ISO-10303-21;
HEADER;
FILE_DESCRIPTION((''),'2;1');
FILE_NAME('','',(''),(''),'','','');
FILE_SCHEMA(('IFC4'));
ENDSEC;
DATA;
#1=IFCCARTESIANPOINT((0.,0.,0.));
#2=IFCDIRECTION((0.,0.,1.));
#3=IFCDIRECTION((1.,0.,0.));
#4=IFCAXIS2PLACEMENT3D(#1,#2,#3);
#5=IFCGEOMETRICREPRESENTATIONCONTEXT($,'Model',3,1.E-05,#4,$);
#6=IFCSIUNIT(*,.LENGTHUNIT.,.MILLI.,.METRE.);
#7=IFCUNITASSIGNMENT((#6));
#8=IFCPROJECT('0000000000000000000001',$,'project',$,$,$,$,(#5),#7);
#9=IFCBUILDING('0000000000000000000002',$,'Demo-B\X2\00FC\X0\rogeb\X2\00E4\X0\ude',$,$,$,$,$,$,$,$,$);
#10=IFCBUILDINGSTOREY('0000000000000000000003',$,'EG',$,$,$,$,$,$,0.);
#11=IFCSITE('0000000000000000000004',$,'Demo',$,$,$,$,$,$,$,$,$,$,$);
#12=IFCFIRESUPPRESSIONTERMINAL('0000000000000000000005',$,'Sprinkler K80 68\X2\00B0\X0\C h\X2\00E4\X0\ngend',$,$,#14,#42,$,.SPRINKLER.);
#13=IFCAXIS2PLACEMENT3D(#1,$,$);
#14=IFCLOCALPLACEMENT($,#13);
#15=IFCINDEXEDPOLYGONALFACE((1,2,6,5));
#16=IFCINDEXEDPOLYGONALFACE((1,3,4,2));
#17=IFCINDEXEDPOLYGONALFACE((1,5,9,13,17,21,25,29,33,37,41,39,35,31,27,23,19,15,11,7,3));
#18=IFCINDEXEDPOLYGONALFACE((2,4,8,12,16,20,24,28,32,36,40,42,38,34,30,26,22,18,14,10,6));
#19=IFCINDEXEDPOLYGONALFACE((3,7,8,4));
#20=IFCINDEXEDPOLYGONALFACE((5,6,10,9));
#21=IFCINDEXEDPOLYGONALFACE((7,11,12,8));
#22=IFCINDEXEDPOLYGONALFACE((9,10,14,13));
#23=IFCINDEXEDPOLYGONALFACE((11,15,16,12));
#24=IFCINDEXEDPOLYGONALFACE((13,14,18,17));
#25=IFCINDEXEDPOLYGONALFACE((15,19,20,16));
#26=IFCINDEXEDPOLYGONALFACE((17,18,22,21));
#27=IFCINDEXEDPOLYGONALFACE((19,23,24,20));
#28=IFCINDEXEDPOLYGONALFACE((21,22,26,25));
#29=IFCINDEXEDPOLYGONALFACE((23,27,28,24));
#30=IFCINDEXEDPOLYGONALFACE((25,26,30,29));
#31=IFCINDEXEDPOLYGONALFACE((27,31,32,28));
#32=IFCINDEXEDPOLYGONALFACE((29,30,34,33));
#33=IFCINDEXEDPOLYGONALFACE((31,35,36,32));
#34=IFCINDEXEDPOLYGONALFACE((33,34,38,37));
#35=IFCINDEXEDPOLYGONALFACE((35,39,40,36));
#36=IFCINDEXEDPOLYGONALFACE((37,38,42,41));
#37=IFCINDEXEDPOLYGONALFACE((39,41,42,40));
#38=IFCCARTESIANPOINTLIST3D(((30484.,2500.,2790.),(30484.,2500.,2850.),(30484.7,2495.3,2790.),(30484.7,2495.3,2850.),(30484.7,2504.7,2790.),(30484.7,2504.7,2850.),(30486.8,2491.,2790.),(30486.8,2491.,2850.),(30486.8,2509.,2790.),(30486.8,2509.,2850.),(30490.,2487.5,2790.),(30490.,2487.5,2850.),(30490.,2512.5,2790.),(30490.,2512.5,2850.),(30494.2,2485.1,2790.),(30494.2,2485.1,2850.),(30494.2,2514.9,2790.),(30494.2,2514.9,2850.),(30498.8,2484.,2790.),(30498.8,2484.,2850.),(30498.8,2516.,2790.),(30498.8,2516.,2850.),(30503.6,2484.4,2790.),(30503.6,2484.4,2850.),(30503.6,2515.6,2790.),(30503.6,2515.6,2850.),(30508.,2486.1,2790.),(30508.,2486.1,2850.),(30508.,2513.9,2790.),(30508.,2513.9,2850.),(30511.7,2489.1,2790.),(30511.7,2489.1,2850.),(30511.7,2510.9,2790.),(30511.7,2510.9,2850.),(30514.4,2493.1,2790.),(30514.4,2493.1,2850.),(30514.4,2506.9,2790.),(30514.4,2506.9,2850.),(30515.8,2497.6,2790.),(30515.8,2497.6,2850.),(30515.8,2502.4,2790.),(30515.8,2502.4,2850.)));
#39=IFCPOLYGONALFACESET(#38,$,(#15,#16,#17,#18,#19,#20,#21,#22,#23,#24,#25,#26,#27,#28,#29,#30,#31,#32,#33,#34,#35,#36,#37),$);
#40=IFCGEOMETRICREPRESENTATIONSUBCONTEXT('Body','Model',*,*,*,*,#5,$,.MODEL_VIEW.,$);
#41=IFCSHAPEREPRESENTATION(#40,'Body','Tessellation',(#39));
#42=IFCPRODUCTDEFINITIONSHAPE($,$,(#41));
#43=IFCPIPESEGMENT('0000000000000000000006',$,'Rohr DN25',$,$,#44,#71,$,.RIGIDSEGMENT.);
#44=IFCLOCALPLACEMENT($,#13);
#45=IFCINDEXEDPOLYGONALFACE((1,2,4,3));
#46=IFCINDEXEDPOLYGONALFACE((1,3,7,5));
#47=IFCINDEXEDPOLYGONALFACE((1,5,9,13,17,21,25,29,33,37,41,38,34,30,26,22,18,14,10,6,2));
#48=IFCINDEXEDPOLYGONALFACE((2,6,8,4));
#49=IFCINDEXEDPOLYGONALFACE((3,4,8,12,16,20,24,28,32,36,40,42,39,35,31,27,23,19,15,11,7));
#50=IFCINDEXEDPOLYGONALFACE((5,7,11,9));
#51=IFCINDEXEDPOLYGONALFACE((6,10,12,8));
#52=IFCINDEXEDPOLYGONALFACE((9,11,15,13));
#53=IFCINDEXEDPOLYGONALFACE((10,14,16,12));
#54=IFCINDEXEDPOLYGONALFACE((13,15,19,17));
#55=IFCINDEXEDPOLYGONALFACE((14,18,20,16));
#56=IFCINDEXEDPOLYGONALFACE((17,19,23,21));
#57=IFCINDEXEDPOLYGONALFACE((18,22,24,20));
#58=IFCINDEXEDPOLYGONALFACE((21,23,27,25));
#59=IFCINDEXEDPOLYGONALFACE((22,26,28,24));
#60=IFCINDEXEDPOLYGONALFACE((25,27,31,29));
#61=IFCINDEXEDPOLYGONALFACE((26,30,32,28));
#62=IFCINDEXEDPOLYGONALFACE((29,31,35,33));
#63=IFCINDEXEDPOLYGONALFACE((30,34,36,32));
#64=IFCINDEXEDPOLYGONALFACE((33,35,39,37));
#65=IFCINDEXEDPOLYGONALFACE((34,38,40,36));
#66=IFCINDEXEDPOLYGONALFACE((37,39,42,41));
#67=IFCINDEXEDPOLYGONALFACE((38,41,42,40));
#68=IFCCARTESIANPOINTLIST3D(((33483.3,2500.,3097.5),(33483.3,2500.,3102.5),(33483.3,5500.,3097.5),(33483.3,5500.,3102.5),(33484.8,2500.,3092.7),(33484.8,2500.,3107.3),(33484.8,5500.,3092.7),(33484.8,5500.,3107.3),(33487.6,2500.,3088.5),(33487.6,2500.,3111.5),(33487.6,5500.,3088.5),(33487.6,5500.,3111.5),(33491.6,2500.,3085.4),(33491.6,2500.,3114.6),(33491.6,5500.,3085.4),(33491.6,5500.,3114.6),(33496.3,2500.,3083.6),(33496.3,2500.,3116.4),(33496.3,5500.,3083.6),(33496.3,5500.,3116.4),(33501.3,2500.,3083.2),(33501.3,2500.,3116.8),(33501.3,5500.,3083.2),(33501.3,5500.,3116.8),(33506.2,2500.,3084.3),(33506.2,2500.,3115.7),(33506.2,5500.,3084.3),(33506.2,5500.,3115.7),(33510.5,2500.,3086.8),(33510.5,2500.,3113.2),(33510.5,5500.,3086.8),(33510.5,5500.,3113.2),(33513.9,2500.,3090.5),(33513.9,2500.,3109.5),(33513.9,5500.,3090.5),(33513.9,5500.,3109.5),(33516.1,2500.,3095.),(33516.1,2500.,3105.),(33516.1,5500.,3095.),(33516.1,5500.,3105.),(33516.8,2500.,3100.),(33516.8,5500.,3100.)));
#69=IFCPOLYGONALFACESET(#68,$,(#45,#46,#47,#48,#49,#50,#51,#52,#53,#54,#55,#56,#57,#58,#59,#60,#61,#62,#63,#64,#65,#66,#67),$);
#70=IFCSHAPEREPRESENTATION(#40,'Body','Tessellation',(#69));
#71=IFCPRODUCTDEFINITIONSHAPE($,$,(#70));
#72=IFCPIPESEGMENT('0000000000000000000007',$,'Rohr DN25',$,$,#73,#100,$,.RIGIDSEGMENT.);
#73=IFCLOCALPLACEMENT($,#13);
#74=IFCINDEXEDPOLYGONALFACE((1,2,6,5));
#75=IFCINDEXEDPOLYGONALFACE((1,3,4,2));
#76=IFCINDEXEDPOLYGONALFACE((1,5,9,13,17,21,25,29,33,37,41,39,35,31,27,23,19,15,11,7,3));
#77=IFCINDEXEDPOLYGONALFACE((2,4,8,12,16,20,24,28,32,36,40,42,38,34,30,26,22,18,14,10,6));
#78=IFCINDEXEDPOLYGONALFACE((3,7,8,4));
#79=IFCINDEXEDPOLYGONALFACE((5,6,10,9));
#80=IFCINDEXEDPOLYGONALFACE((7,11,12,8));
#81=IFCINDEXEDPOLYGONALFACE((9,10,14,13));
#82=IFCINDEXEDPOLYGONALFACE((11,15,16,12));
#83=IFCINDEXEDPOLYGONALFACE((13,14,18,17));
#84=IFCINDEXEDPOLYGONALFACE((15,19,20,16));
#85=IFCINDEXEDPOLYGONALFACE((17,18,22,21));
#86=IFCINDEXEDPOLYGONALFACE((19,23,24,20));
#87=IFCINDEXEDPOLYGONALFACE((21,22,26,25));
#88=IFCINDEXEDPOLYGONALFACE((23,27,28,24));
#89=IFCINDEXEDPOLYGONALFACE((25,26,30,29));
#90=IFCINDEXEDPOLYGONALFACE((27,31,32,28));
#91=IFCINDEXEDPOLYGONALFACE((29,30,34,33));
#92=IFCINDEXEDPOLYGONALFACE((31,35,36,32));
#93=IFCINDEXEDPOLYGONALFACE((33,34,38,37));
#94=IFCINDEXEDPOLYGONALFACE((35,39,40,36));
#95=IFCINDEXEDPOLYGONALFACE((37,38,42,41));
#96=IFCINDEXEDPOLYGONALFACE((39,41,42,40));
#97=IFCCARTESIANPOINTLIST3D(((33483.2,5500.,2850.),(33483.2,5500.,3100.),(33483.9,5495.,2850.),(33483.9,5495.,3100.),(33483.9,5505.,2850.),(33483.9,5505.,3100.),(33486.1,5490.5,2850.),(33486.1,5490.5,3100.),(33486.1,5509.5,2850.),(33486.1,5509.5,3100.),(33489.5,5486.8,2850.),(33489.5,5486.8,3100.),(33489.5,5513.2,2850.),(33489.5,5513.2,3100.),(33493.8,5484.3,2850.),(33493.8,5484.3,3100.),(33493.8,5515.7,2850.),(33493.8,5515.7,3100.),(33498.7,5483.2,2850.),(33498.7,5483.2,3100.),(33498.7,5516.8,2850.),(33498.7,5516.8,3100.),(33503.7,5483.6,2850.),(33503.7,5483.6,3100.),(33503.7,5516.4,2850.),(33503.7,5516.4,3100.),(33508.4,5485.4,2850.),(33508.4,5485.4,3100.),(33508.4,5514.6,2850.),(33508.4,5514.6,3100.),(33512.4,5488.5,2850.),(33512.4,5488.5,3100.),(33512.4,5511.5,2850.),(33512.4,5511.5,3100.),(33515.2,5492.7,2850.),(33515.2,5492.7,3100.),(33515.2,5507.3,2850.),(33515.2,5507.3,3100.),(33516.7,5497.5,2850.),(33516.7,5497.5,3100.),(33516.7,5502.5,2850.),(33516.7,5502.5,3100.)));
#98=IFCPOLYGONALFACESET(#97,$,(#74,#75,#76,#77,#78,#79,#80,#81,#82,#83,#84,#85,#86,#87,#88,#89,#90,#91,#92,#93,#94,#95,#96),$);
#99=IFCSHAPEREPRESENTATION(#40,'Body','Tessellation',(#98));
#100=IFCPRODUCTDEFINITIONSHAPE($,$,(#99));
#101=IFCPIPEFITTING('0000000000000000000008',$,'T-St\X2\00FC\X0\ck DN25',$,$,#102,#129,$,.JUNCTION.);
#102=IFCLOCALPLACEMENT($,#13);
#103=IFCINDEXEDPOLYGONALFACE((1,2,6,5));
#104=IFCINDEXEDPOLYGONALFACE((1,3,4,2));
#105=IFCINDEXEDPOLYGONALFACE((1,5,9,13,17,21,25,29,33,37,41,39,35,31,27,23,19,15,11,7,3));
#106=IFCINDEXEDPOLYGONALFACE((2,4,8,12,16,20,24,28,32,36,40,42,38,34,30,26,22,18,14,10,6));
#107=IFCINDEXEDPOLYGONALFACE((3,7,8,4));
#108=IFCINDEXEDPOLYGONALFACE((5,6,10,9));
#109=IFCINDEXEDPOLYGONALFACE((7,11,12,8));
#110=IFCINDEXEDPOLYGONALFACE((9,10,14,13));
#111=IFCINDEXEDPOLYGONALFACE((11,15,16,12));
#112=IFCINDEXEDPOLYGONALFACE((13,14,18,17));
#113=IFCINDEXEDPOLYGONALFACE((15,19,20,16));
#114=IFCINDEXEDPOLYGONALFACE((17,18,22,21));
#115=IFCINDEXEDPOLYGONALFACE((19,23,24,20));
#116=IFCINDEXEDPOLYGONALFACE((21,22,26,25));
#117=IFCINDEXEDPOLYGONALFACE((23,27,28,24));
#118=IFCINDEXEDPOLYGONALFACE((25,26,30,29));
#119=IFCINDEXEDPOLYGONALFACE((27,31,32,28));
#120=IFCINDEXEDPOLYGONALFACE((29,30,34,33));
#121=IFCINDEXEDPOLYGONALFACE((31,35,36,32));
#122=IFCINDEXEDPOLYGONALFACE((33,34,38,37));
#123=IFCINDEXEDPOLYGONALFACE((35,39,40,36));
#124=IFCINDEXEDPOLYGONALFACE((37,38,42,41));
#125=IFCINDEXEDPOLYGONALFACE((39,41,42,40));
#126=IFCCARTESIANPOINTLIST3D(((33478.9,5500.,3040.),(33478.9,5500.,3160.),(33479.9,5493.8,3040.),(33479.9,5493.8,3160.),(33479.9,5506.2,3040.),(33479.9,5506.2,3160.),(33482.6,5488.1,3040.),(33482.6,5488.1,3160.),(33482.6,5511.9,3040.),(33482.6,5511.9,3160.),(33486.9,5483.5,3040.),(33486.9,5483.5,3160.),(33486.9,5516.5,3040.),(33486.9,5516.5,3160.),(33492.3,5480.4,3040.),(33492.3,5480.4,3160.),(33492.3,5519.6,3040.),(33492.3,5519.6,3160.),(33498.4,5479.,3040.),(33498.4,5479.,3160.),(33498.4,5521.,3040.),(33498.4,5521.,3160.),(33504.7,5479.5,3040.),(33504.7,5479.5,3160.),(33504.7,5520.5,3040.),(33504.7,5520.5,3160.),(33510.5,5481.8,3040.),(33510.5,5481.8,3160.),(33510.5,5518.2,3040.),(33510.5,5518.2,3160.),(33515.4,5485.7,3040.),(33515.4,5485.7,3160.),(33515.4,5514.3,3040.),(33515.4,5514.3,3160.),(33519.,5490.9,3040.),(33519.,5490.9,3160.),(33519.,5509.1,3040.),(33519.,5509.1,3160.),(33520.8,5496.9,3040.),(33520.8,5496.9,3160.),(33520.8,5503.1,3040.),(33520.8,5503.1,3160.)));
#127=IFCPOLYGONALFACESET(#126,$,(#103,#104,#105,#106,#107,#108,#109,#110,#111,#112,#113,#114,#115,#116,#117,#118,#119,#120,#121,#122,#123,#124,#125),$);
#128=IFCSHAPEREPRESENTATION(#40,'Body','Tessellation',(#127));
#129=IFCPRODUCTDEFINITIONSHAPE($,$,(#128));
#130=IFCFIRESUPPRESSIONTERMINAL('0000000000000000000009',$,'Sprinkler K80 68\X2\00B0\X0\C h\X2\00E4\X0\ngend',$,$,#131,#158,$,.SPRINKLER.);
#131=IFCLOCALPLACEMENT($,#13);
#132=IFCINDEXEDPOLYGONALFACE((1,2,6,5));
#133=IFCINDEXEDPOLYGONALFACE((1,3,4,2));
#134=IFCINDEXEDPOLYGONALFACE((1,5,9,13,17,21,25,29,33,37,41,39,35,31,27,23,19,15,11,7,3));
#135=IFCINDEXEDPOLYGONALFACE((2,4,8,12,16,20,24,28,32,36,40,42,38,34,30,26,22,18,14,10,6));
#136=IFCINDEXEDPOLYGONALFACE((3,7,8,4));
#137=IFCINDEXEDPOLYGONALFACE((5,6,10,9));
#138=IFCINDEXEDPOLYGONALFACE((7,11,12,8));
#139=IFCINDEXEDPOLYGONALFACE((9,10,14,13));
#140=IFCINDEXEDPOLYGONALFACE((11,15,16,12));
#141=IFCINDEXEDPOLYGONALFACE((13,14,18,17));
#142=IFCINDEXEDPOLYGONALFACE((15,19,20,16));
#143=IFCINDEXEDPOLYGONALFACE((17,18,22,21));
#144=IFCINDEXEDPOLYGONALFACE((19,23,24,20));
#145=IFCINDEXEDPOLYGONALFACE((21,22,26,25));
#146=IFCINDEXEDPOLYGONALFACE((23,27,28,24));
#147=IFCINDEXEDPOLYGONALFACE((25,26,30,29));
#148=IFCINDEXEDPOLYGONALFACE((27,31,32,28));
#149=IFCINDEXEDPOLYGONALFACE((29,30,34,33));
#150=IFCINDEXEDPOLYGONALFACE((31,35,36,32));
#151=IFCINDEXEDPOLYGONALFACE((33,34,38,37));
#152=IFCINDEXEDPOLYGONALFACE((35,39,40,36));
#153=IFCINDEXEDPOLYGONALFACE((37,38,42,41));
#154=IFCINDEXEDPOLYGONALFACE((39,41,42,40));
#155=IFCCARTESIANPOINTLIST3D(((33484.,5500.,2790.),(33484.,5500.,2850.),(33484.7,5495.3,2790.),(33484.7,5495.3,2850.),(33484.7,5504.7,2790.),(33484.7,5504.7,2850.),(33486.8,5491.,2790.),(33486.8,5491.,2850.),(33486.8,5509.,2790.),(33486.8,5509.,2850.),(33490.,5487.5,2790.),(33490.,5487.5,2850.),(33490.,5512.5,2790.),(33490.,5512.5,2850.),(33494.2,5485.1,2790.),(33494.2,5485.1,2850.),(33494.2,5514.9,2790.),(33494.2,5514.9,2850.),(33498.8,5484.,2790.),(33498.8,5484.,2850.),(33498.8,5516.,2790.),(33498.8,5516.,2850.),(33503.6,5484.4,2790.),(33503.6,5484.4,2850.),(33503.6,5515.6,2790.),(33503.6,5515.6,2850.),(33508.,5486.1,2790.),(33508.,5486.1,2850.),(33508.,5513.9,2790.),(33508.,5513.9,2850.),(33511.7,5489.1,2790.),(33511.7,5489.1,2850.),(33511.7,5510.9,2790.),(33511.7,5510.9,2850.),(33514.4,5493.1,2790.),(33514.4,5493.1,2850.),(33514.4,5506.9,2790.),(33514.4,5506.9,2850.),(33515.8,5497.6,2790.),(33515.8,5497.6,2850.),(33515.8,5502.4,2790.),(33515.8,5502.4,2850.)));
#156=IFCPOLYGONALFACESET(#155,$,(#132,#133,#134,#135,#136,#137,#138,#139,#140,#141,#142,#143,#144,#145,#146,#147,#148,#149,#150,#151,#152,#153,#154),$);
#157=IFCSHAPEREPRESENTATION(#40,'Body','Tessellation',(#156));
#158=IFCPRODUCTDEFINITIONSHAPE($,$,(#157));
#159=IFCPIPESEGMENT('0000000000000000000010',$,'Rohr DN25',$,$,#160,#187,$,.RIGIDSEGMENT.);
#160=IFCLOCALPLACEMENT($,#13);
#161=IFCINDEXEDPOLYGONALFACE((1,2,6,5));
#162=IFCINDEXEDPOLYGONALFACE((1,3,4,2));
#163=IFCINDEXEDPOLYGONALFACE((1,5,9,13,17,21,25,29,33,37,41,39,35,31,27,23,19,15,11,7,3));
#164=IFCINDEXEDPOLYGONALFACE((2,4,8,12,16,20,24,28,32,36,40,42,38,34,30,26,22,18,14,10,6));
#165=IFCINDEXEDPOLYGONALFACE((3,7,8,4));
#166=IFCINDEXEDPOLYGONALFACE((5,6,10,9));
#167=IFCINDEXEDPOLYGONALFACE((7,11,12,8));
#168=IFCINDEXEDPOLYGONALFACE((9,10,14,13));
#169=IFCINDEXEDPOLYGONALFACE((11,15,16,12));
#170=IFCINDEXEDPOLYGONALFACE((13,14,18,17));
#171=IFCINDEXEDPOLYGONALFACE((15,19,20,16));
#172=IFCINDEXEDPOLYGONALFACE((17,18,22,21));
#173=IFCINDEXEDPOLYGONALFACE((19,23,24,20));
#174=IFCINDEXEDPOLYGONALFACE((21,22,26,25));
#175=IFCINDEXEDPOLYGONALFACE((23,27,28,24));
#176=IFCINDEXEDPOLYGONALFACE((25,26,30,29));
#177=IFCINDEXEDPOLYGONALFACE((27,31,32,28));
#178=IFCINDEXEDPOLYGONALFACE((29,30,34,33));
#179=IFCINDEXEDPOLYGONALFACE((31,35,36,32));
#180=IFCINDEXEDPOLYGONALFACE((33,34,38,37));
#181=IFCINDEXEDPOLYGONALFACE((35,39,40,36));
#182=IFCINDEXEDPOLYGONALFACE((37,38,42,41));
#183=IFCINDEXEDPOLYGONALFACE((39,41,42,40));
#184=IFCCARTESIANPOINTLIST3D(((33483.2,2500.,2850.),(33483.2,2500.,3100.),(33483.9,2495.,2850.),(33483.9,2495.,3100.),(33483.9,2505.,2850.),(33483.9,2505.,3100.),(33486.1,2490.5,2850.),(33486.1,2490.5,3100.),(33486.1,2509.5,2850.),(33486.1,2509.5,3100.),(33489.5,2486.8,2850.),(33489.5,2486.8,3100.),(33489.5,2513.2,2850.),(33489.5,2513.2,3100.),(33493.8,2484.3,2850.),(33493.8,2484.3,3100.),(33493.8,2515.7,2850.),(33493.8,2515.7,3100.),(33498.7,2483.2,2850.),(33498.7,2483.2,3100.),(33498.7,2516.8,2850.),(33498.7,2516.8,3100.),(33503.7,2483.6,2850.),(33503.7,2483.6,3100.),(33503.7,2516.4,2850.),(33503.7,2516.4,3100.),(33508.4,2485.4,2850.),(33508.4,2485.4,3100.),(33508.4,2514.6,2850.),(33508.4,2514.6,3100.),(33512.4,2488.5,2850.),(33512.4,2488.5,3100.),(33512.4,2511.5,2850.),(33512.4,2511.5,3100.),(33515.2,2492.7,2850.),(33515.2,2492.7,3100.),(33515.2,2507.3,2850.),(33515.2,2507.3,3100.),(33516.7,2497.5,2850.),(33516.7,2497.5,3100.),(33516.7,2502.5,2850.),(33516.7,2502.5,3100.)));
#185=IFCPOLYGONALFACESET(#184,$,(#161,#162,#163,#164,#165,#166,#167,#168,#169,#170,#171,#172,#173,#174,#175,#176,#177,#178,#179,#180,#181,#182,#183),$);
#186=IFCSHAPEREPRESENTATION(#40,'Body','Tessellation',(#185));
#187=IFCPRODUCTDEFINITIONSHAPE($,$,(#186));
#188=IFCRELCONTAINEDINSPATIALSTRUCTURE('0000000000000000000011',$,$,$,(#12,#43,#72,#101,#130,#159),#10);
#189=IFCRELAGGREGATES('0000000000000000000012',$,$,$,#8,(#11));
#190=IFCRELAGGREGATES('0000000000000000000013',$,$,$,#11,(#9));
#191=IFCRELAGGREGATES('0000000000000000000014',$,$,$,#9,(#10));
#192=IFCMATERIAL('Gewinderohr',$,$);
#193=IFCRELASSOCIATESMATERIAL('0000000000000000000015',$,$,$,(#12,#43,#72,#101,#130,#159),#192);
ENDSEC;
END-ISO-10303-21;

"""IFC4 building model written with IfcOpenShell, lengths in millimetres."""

from ifc_helpers import new_model, si_unit, frame, origin_with_axes, place, context, subcontext, project, spatial, circle, extrude, material, element, save


model = new_model("IFC4")

# Units and contexts
model_context = context("Model", 3, precision=1e-05, world=origin_with_axes())
body_context = subcontext(model_context, "Body", "Model", "MODEL_VIEW")
ifc_project = project(units=[si_unit("LENGTHUNIT", "METRE", prefix="MILLI")], contexts=[model_context])

# Site, building, storey
site = spatial("IfcSite", under=ifc_project, Name="Demo")
building = spatial("IfcBuilding", under=site, Name="Demo-Bürogebäude")
storey = spatial("IfcBuildingStorey", under=building, Name="EG", Elevation=0.0)

# Shared definitions
ifc_material_1 = material(Name="Gewinderohr")

# Fire suppression terminal
fire_suppression_terminal_1_placement = place(None, frame((30500.0, 2500.0, 2850.0), z_axis=(0.0, 0.0, -1.0), x_axis=(-1.0, 0.0, 0.0)))
element("IfcFireSuppressionTerminal", 1, at=fire_suppression_terminal_1_placement, inside=storey, material=ifc_material_1, Name="Sprinkler K80 68°C hängend", PredefinedType="SPRINKLER", context=body_context, shape_type="SweptSolid", body=[
    extrude(circle(Radius=16.0), origin_with_axes(), (0.0, 0.0, 1.0), 60.0),
])

# Pipe segments
pipe_segment_1_placement = place(None, frame((33500.0, 5500.0, 3100.0), z_axis=(0.0, -1.0, 0.0), x_axis=(1.0, 0.0, 0.0)))
element("IfcPipeSegment", 2, at=pipe_segment_1_placement, inside=storey, material=ifc_material_1, Name="Rohr DN25", PredefinedType="RIGIDSEGMENT", context=body_context, shape_type="SweptSolid", body=[
    extrude(circle(Radius=16.9), origin_with_axes(), (0.0, 0.0, 1.0), 3000.0),
])
pipe_segment_2_placement = place(None, frame((33500.0, 5500.0, 3100.0), z_axis=(0.0, 0.0, -1.0), x_axis=(-1.0, 0.0, 0.0)))
element("IfcPipeSegment", 3, at=pipe_segment_2_placement, inside=storey, material=ifc_material_1, Name="Rohr DN25", PredefinedType="RIGIDSEGMENT", context=body_context, shape_type="SweptSolid", body=[
    extrude(circle(Radius=16.9), origin_with_axes(), (0.0, 0.0, 1.0), 250.0),
])

# Pipe fitting
pipe_fitting_1_placement = place(None, frame((33500.0, 5500.0, 3160.0), z_axis=(0.0, 0.0, -1.0), x_axis=(-1.0, 0.0, 0.0)))
element("IfcPipeFitting", 4, at=pipe_fitting_1_placement, inside=storey, material=ifc_material_1, Name="T-Stück DN25", PredefinedType="JUNCTION", context=body_context, shape_type="SweptSolid", body=[
    extrude(circle(Radius=21.1), origin_with_axes(), (0.0, 0.0, 1.0), 120.0),
])

# Fire suppression terminal
fire_suppression_terminal_2_placement = place(None, frame((33500.0, 5500.0, 2850.0), z_axis=(0.0, 0.0, -1.0), x_axis=(-1.0, 0.0, 0.0)))
element("IfcFireSuppressionTerminal", 5, at=fire_suppression_terminal_2_placement, inside=storey, material=ifc_material_1, Name="Sprinkler K80 68°C hängend", PredefinedType="SPRINKLER", context=body_context, shape_type="SweptSolid", body=[
    extrude(circle(Radius=16.0), origin_with_axes(), (0.0, 0.0, 1.0), 60.0),
])

# Pipe segment
pipe_segment_3_placement = place(None, frame((33500.0, 2500.0, 3100.0), z_axis=(0.0, 0.0, -1.0), x_axis=(-1.0, 0.0, 0.0)))
element("IfcPipeSegment", 6, at=pipe_segment_3_placement, inside=storey, material=ifc_material_1, Name="Rohr DN25", PredefinedType="RIGIDSEGMENT", context=body_context, shape_type="SweptSolid", body=[
    extrude(circle(Radius=16.9), origin_with_axes(), (0.0, 0.0, 1.0), 250.0),
])

save(model, "model.ifc")
